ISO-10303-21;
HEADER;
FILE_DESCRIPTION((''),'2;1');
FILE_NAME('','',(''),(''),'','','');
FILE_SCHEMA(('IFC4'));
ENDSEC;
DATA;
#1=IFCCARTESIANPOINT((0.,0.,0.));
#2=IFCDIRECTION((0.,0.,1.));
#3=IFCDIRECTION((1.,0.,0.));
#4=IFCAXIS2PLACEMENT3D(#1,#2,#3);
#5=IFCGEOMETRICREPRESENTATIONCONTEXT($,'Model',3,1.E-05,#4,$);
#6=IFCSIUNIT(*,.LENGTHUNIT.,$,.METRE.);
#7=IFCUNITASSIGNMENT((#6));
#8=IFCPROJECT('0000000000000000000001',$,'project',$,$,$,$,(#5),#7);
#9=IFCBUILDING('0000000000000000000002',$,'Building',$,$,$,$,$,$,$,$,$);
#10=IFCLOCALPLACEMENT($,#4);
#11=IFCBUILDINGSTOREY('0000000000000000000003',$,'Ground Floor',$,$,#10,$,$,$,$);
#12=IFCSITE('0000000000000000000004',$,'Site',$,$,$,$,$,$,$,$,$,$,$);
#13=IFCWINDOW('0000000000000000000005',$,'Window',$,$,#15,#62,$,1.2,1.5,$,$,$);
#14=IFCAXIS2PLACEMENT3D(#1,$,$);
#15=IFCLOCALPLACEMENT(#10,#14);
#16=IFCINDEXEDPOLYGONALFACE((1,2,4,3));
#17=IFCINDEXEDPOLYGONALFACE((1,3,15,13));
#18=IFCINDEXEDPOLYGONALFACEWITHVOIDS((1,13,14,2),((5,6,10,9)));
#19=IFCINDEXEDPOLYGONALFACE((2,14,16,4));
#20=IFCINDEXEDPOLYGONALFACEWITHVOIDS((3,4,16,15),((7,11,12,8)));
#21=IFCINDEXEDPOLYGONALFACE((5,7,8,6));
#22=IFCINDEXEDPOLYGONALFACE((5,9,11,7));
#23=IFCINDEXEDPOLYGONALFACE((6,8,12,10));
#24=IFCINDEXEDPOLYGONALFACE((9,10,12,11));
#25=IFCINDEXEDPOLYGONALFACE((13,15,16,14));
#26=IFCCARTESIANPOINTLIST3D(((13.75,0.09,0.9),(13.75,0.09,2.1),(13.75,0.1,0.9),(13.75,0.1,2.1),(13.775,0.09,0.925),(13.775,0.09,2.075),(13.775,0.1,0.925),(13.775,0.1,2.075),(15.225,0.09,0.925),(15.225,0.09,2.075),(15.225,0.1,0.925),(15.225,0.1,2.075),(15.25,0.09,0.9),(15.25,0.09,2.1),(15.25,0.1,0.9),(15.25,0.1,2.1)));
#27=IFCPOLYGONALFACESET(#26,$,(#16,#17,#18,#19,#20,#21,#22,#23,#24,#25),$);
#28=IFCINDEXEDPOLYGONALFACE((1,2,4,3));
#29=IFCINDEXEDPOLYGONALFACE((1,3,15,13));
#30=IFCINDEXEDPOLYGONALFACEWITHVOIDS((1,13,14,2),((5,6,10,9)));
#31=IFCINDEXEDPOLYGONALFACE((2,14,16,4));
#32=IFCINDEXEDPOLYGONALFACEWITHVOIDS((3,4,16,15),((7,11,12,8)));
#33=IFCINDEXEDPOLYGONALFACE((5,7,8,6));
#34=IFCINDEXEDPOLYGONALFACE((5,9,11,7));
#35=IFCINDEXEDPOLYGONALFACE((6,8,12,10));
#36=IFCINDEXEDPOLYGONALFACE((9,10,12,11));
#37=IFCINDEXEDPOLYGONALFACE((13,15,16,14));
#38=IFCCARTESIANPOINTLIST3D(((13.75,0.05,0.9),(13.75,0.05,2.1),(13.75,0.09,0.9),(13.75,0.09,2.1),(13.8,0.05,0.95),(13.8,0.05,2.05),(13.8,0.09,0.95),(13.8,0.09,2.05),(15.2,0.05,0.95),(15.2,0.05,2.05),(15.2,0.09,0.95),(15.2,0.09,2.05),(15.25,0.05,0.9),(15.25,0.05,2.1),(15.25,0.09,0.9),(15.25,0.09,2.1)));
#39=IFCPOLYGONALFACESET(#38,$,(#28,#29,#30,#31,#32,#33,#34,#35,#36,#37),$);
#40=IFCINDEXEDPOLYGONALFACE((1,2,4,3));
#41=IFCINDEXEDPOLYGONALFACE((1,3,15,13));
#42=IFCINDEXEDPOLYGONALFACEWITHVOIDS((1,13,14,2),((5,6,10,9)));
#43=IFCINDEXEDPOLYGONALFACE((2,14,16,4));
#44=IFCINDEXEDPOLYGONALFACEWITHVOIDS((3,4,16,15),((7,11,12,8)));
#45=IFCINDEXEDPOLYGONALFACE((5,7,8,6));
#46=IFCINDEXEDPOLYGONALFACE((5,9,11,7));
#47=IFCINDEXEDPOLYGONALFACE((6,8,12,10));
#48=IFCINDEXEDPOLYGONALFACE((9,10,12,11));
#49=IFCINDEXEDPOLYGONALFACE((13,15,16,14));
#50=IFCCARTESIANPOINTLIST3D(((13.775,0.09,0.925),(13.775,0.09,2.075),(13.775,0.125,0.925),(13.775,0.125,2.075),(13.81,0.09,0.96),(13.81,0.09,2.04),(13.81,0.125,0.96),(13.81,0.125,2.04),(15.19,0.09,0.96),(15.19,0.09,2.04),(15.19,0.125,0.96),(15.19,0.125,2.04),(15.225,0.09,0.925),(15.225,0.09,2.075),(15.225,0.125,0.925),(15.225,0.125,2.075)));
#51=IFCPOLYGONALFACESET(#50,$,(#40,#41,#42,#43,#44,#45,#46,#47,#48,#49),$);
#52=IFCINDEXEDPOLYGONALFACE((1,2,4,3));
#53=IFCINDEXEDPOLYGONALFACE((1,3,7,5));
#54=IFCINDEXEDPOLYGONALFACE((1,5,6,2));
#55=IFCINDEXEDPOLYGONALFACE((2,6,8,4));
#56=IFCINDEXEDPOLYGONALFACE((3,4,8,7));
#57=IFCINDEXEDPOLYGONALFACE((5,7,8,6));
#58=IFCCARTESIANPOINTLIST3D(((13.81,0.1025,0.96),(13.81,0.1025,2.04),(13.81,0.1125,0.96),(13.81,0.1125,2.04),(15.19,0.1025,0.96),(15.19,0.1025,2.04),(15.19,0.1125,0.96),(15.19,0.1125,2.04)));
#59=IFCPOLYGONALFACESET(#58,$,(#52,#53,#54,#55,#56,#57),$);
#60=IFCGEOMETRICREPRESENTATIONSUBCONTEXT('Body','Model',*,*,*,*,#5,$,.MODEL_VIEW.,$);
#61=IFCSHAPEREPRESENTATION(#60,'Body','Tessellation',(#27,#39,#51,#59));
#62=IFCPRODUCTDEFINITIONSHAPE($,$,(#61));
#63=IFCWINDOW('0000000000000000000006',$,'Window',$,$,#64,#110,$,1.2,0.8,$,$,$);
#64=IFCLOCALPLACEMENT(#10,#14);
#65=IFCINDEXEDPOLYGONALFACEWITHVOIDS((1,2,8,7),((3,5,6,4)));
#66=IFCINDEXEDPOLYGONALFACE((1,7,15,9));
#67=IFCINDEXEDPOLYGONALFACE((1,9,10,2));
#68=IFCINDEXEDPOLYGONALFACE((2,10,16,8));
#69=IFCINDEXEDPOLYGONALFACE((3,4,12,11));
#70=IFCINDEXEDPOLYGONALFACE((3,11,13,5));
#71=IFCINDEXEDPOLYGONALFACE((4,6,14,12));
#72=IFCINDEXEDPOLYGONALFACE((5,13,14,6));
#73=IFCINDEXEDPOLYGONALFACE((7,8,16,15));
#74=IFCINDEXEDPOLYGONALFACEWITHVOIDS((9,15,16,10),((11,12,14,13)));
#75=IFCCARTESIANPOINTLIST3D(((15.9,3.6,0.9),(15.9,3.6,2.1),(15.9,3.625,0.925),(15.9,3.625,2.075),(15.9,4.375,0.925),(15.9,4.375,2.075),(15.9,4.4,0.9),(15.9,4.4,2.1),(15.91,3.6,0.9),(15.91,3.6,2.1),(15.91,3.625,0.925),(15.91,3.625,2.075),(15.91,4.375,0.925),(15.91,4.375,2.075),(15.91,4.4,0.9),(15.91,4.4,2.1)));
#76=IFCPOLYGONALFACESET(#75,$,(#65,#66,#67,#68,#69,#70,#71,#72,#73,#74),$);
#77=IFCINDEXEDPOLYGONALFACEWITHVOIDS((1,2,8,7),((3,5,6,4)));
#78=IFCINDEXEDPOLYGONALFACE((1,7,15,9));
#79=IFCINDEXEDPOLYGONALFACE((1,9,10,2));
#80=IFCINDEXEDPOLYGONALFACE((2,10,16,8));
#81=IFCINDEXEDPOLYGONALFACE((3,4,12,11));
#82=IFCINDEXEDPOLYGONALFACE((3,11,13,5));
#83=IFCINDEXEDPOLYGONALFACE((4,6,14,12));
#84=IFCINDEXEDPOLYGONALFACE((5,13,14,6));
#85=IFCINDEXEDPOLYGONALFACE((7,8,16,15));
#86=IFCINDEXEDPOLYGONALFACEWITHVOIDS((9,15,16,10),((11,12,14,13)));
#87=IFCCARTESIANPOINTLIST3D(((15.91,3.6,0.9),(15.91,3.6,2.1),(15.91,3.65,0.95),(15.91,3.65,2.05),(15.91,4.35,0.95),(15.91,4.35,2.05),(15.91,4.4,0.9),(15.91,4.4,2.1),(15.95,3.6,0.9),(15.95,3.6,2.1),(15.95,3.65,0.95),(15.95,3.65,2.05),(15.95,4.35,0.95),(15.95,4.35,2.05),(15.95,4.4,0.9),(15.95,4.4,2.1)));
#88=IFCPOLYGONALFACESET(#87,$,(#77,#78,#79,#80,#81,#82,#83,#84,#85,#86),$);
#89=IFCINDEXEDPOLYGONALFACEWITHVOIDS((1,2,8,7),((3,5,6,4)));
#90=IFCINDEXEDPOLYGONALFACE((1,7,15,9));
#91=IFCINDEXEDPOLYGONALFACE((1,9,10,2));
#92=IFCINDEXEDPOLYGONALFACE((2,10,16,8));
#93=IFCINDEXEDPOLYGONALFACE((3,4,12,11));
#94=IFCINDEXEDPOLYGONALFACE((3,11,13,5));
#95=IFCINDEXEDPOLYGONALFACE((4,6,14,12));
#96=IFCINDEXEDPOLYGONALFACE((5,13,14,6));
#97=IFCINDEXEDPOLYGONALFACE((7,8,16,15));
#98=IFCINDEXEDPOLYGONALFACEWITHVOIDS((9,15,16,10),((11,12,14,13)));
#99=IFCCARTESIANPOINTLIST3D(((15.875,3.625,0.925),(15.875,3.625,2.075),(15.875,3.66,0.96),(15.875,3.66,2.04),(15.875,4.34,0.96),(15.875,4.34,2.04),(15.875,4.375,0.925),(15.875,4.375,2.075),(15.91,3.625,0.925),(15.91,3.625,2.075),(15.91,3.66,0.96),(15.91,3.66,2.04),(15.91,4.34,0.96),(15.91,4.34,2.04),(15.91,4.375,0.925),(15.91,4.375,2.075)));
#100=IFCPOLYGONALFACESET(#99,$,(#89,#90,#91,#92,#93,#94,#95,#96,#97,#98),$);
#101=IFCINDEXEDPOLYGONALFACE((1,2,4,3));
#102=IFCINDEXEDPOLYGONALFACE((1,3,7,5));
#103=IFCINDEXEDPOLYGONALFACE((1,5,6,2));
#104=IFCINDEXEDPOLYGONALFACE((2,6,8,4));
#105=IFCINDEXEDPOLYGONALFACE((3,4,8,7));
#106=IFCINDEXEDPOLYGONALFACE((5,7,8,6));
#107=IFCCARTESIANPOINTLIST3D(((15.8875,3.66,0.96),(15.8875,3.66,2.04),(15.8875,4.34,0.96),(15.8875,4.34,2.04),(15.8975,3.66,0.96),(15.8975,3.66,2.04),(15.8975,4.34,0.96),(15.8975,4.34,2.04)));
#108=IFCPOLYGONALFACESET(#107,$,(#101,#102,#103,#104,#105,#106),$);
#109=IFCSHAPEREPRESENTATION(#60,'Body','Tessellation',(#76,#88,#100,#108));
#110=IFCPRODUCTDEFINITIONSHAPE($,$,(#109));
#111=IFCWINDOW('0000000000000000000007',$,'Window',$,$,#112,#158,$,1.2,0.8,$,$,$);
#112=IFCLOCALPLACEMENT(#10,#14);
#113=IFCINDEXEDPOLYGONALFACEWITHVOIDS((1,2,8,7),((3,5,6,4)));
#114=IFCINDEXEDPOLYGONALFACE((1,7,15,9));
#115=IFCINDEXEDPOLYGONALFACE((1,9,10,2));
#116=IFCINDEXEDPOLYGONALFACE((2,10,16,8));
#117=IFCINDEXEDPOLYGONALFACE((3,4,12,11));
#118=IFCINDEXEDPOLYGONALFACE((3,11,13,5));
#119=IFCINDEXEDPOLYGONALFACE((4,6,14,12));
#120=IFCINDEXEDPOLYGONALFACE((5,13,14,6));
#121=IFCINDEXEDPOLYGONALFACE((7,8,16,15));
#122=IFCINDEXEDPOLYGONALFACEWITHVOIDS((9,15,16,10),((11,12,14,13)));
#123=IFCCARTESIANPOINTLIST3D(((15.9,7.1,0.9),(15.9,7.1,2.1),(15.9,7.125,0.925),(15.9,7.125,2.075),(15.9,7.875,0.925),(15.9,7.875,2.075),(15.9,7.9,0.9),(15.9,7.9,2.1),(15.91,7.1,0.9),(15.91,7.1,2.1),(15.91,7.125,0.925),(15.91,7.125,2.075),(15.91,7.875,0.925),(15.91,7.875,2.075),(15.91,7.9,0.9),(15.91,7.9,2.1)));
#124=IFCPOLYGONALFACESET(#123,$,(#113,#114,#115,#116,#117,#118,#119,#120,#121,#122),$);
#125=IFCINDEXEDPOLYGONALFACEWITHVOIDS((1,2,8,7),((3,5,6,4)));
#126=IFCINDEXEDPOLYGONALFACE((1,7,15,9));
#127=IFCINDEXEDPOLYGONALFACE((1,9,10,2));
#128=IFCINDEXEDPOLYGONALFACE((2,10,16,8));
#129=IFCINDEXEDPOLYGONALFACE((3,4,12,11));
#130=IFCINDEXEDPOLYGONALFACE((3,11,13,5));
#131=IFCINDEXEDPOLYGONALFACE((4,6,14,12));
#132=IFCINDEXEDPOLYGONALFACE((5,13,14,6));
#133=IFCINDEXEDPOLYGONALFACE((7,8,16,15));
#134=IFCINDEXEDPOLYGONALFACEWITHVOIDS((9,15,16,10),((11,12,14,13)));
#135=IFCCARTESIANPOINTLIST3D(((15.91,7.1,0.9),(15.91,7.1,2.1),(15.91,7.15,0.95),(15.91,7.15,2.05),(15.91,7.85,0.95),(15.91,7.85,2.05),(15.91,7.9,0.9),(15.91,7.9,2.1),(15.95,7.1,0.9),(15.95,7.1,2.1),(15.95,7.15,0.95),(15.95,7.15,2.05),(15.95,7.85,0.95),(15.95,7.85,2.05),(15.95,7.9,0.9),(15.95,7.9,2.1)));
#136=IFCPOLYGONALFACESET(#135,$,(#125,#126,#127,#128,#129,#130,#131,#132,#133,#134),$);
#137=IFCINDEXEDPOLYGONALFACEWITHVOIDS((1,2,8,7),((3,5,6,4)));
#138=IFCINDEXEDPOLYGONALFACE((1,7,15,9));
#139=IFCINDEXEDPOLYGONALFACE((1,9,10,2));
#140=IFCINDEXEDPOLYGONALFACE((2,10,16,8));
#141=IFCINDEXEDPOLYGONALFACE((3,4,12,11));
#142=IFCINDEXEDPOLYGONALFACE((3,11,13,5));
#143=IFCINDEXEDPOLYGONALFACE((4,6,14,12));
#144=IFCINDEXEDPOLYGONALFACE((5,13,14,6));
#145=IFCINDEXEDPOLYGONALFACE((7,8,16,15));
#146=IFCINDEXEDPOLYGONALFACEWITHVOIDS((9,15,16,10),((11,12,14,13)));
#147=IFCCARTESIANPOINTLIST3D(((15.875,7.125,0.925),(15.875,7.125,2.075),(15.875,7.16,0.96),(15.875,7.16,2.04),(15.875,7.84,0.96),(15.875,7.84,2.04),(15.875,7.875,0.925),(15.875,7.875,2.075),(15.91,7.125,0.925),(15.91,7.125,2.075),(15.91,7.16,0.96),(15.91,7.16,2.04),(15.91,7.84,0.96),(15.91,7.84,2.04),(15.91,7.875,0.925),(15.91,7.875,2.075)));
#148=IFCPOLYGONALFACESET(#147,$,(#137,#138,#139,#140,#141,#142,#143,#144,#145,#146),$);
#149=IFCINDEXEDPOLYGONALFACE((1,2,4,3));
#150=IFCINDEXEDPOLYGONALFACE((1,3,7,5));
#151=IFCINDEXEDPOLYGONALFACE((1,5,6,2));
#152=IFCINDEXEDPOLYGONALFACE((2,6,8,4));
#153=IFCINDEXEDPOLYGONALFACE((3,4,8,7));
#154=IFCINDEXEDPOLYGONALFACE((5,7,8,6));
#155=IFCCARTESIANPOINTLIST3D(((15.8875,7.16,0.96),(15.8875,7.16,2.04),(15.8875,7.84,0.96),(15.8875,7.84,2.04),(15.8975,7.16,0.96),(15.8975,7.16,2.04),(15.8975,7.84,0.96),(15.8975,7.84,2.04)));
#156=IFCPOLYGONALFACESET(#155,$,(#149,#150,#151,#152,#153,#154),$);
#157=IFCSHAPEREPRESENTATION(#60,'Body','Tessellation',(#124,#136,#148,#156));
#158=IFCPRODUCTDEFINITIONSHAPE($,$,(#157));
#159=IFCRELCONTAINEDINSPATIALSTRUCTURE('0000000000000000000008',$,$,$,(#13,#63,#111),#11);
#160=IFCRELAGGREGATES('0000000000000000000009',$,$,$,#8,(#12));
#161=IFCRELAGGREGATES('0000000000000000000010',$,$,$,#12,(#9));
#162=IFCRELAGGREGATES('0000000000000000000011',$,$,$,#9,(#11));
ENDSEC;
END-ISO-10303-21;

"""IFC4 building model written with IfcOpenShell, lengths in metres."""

from ifc_helpers import new_model, si_unit, frame, origin_with_axes, place, context, subcontext, project, spatial, line, indexed_curve, outline, extrude, element, save


model = new_model("IFC4")

# Units and contexts
model_context = context("Model", 3, precision=1e-05, world=origin_with_axes())
body_context = subcontext(model_context, "Body", "Model", "MODEL_VIEW")
ifc_project = project(units=[si_unit("LENGTHUNIT", "METRE")], contexts=[model_context])

# Site, building, storey
site = spatial("IfcSite", under=ifc_project, Name="Site")
building = spatial("IfcBuilding", under=site, Name="Building")
storey_placement = place(None, origin_with_axes())
storey = spatial("IfcBuildingStorey", under=building, at=storey_placement, Name="Ground Floor")

# Windows
window_placement = place(storey_placement, frame((13.75, 0.0, 0.9), z_axis=(0.0, 0.0, 1.0), x_axis=(1.0, 0.0, 0.0)))
element("IfcWindow", 1, at=window_placement, inside=storey, Name="Window", OverallHeight=1.2, OverallWidth=1.5, context=body_context, shape_type="SweptSolid", body=[
    extrude(outline(indexed_curve([(0.0, 0.0), (1.5, 0.0), (1.5, 1.2), (0.0, 1.2)], segments=[line(1, 2, 3, 4, 1)]), holes=[indexed_curve([(0.025, 0.025), (1.475, 0.025), (1.475, 1.175), (0.025, 1.175)], segments=[line(1, 2, 3, 4, 1)])]), frame((0.0, 0.09, 0.0), z_axis=(0.0, -1.0, 0.0), x_axis=(1.0, 0.0, 0.0)), (0.0, 0.0, -1.0), 0.01),
    extrude(outline(indexed_curve([(0.0, 0.0), (1.5, 0.0), (1.5, 1.2), (0.0, 1.2)], segments=[line(1, 2, 3, 4, 1)]), holes=[indexed_curve([(0.05, 0.05), (1.45, 0.05), (1.45, 1.15), (0.05, 1.15)], segments=[line(1, 2, 3, 4, 1)])]), frame((0.0, 0.05, 0.0), z_axis=(0.0, -1.0, 0.0), x_axis=(1.0, 0.0, 0.0)), (0.0, 0.0, -1.0), 0.04),
    extrude(outline(indexed_curve([(0.0, 0.0), (1.45, 0.0), (1.45, 1.15), (0.0, 1.15)], segments=[line(1, 2, 3, 4, 1)]), holes=[indexed_curve([(0.035, 0.035), (1.415, 0.035), (1.415, 1.115), (0.035, 1.115)], segments=[line(1, 2, 3, 4, 1)])]), frame((0.025, 0.09, 0.025), z_axis=(0.0, -1.0, 0.0), x_axis=(1.0, 0.0, 0.0)), (0.0, 0.0, -1.0), 0.035),
    extrude(outline(indexed_curve([(0.035, 0.035), (1.415, 0.035), (1.415, 1.115), (0.035, 1.115)], segments=[line(1, 2, 3, 4, 1)])), frame((0.025, 0.1025, 0.025), z_axis=(0.0, -1.0, 0.0), x_axis=(1.0, 0.0, 0.0)), (0.0, 0.0, -1.0), 0.01),
])
for number, where, z_axis, x_axis, name in (
    (2, (16.0, 3.6, 0.9), (0.0, 0.0, 1.0), (0.0, 1.0, 0.0), "Window"),
    (3, (16.0, 7.1, 0.9), (0.0, 0.0, 1.0), (0.0, 1.0, 0.0), "Window"),
):
    element("IfcWindow", number, at=place(storey_placement, frame(where, z_axis=z_axis, x_axis=x_axis)), inside=storey, Name=name, OverallHeight=1.2, OverallWidth=0.8, context=body_context, shape_type="SweptSolid", body=[
        extrude(outline(indexed_curve([(0.0, 0.0), (0.8, 0.0), (0.8, 1.2), (0.0, 1.2)], segments=[line(1, 2, 3, 4, 1)]), holes=[indexed_curve([(0.025, 0.025), (0.775, 0.025), (0.775, 1.175), (0.025, 1.175)], segments=[line(1, 2, 3, 4, 1)])]), frame((0.0, 0.09, 0.0), z_axis=(0.0, -1.0, 0.0), x_axis=(1.0, 0.0, 0.0)), (0.0, 0.0, -1.0), 0.01),
        extrude(outline(indexed_curve([(0.0, 0.0), (0.8, 0.0), (0.8, 1.2), (0.0, 1.2)], segments=[line(1, 2, 3, 4, 1)]), holes=[indexed_curve([(0.05, 0.05), (0.75, 0.05), (0.75, 1.15), (0.05, 1.15)], segments=[line(1, 2, 3, 4, 1)])]), frame((0.0, 0.05, 0.0), z_axis=(0.0, -1.0, 0.0), x_axis=(1.0, 0.0, 0.0)), (0.0, 0.0, -1.0), 0.04),
        extrude(outline(indexed_curve([(0.0, 0.0), (0.75, 0.0), (0.75, 1.15), (0.0, 1.15)], segments=[line(1, 2, 3, 4, 1)]), holes=[indexed_curve([(0.035, 0.035), (0.715, 0.035), (0.715, 1.115), (0.035, 1.115)], segments=[line(1, 2, 3, 4, 1)])]), frame((0.025, 0.09, 0.025), z_axis=(0.0, -1.0, 0.0), x_axis=(1.0, 0.0, 0.0)), (0.0, 0.0, -1.0), 0.035),
        extrude(outline(indexed_curve([(0.035, 0.035), (0.715, 0.035), (0.715, 1.115), (0.035, 1.115)], segments=[line(1, 2, 3, 4, 1)])), frame((0.025, 0.1025, 0.025), z_axis=(0.0, -1.0, 0.0), x_axis=(1.0, 0.0, 0.0)), (0.0, 0.0, -1.0), 0.01),
    ])

save(model, "model.ifc")
